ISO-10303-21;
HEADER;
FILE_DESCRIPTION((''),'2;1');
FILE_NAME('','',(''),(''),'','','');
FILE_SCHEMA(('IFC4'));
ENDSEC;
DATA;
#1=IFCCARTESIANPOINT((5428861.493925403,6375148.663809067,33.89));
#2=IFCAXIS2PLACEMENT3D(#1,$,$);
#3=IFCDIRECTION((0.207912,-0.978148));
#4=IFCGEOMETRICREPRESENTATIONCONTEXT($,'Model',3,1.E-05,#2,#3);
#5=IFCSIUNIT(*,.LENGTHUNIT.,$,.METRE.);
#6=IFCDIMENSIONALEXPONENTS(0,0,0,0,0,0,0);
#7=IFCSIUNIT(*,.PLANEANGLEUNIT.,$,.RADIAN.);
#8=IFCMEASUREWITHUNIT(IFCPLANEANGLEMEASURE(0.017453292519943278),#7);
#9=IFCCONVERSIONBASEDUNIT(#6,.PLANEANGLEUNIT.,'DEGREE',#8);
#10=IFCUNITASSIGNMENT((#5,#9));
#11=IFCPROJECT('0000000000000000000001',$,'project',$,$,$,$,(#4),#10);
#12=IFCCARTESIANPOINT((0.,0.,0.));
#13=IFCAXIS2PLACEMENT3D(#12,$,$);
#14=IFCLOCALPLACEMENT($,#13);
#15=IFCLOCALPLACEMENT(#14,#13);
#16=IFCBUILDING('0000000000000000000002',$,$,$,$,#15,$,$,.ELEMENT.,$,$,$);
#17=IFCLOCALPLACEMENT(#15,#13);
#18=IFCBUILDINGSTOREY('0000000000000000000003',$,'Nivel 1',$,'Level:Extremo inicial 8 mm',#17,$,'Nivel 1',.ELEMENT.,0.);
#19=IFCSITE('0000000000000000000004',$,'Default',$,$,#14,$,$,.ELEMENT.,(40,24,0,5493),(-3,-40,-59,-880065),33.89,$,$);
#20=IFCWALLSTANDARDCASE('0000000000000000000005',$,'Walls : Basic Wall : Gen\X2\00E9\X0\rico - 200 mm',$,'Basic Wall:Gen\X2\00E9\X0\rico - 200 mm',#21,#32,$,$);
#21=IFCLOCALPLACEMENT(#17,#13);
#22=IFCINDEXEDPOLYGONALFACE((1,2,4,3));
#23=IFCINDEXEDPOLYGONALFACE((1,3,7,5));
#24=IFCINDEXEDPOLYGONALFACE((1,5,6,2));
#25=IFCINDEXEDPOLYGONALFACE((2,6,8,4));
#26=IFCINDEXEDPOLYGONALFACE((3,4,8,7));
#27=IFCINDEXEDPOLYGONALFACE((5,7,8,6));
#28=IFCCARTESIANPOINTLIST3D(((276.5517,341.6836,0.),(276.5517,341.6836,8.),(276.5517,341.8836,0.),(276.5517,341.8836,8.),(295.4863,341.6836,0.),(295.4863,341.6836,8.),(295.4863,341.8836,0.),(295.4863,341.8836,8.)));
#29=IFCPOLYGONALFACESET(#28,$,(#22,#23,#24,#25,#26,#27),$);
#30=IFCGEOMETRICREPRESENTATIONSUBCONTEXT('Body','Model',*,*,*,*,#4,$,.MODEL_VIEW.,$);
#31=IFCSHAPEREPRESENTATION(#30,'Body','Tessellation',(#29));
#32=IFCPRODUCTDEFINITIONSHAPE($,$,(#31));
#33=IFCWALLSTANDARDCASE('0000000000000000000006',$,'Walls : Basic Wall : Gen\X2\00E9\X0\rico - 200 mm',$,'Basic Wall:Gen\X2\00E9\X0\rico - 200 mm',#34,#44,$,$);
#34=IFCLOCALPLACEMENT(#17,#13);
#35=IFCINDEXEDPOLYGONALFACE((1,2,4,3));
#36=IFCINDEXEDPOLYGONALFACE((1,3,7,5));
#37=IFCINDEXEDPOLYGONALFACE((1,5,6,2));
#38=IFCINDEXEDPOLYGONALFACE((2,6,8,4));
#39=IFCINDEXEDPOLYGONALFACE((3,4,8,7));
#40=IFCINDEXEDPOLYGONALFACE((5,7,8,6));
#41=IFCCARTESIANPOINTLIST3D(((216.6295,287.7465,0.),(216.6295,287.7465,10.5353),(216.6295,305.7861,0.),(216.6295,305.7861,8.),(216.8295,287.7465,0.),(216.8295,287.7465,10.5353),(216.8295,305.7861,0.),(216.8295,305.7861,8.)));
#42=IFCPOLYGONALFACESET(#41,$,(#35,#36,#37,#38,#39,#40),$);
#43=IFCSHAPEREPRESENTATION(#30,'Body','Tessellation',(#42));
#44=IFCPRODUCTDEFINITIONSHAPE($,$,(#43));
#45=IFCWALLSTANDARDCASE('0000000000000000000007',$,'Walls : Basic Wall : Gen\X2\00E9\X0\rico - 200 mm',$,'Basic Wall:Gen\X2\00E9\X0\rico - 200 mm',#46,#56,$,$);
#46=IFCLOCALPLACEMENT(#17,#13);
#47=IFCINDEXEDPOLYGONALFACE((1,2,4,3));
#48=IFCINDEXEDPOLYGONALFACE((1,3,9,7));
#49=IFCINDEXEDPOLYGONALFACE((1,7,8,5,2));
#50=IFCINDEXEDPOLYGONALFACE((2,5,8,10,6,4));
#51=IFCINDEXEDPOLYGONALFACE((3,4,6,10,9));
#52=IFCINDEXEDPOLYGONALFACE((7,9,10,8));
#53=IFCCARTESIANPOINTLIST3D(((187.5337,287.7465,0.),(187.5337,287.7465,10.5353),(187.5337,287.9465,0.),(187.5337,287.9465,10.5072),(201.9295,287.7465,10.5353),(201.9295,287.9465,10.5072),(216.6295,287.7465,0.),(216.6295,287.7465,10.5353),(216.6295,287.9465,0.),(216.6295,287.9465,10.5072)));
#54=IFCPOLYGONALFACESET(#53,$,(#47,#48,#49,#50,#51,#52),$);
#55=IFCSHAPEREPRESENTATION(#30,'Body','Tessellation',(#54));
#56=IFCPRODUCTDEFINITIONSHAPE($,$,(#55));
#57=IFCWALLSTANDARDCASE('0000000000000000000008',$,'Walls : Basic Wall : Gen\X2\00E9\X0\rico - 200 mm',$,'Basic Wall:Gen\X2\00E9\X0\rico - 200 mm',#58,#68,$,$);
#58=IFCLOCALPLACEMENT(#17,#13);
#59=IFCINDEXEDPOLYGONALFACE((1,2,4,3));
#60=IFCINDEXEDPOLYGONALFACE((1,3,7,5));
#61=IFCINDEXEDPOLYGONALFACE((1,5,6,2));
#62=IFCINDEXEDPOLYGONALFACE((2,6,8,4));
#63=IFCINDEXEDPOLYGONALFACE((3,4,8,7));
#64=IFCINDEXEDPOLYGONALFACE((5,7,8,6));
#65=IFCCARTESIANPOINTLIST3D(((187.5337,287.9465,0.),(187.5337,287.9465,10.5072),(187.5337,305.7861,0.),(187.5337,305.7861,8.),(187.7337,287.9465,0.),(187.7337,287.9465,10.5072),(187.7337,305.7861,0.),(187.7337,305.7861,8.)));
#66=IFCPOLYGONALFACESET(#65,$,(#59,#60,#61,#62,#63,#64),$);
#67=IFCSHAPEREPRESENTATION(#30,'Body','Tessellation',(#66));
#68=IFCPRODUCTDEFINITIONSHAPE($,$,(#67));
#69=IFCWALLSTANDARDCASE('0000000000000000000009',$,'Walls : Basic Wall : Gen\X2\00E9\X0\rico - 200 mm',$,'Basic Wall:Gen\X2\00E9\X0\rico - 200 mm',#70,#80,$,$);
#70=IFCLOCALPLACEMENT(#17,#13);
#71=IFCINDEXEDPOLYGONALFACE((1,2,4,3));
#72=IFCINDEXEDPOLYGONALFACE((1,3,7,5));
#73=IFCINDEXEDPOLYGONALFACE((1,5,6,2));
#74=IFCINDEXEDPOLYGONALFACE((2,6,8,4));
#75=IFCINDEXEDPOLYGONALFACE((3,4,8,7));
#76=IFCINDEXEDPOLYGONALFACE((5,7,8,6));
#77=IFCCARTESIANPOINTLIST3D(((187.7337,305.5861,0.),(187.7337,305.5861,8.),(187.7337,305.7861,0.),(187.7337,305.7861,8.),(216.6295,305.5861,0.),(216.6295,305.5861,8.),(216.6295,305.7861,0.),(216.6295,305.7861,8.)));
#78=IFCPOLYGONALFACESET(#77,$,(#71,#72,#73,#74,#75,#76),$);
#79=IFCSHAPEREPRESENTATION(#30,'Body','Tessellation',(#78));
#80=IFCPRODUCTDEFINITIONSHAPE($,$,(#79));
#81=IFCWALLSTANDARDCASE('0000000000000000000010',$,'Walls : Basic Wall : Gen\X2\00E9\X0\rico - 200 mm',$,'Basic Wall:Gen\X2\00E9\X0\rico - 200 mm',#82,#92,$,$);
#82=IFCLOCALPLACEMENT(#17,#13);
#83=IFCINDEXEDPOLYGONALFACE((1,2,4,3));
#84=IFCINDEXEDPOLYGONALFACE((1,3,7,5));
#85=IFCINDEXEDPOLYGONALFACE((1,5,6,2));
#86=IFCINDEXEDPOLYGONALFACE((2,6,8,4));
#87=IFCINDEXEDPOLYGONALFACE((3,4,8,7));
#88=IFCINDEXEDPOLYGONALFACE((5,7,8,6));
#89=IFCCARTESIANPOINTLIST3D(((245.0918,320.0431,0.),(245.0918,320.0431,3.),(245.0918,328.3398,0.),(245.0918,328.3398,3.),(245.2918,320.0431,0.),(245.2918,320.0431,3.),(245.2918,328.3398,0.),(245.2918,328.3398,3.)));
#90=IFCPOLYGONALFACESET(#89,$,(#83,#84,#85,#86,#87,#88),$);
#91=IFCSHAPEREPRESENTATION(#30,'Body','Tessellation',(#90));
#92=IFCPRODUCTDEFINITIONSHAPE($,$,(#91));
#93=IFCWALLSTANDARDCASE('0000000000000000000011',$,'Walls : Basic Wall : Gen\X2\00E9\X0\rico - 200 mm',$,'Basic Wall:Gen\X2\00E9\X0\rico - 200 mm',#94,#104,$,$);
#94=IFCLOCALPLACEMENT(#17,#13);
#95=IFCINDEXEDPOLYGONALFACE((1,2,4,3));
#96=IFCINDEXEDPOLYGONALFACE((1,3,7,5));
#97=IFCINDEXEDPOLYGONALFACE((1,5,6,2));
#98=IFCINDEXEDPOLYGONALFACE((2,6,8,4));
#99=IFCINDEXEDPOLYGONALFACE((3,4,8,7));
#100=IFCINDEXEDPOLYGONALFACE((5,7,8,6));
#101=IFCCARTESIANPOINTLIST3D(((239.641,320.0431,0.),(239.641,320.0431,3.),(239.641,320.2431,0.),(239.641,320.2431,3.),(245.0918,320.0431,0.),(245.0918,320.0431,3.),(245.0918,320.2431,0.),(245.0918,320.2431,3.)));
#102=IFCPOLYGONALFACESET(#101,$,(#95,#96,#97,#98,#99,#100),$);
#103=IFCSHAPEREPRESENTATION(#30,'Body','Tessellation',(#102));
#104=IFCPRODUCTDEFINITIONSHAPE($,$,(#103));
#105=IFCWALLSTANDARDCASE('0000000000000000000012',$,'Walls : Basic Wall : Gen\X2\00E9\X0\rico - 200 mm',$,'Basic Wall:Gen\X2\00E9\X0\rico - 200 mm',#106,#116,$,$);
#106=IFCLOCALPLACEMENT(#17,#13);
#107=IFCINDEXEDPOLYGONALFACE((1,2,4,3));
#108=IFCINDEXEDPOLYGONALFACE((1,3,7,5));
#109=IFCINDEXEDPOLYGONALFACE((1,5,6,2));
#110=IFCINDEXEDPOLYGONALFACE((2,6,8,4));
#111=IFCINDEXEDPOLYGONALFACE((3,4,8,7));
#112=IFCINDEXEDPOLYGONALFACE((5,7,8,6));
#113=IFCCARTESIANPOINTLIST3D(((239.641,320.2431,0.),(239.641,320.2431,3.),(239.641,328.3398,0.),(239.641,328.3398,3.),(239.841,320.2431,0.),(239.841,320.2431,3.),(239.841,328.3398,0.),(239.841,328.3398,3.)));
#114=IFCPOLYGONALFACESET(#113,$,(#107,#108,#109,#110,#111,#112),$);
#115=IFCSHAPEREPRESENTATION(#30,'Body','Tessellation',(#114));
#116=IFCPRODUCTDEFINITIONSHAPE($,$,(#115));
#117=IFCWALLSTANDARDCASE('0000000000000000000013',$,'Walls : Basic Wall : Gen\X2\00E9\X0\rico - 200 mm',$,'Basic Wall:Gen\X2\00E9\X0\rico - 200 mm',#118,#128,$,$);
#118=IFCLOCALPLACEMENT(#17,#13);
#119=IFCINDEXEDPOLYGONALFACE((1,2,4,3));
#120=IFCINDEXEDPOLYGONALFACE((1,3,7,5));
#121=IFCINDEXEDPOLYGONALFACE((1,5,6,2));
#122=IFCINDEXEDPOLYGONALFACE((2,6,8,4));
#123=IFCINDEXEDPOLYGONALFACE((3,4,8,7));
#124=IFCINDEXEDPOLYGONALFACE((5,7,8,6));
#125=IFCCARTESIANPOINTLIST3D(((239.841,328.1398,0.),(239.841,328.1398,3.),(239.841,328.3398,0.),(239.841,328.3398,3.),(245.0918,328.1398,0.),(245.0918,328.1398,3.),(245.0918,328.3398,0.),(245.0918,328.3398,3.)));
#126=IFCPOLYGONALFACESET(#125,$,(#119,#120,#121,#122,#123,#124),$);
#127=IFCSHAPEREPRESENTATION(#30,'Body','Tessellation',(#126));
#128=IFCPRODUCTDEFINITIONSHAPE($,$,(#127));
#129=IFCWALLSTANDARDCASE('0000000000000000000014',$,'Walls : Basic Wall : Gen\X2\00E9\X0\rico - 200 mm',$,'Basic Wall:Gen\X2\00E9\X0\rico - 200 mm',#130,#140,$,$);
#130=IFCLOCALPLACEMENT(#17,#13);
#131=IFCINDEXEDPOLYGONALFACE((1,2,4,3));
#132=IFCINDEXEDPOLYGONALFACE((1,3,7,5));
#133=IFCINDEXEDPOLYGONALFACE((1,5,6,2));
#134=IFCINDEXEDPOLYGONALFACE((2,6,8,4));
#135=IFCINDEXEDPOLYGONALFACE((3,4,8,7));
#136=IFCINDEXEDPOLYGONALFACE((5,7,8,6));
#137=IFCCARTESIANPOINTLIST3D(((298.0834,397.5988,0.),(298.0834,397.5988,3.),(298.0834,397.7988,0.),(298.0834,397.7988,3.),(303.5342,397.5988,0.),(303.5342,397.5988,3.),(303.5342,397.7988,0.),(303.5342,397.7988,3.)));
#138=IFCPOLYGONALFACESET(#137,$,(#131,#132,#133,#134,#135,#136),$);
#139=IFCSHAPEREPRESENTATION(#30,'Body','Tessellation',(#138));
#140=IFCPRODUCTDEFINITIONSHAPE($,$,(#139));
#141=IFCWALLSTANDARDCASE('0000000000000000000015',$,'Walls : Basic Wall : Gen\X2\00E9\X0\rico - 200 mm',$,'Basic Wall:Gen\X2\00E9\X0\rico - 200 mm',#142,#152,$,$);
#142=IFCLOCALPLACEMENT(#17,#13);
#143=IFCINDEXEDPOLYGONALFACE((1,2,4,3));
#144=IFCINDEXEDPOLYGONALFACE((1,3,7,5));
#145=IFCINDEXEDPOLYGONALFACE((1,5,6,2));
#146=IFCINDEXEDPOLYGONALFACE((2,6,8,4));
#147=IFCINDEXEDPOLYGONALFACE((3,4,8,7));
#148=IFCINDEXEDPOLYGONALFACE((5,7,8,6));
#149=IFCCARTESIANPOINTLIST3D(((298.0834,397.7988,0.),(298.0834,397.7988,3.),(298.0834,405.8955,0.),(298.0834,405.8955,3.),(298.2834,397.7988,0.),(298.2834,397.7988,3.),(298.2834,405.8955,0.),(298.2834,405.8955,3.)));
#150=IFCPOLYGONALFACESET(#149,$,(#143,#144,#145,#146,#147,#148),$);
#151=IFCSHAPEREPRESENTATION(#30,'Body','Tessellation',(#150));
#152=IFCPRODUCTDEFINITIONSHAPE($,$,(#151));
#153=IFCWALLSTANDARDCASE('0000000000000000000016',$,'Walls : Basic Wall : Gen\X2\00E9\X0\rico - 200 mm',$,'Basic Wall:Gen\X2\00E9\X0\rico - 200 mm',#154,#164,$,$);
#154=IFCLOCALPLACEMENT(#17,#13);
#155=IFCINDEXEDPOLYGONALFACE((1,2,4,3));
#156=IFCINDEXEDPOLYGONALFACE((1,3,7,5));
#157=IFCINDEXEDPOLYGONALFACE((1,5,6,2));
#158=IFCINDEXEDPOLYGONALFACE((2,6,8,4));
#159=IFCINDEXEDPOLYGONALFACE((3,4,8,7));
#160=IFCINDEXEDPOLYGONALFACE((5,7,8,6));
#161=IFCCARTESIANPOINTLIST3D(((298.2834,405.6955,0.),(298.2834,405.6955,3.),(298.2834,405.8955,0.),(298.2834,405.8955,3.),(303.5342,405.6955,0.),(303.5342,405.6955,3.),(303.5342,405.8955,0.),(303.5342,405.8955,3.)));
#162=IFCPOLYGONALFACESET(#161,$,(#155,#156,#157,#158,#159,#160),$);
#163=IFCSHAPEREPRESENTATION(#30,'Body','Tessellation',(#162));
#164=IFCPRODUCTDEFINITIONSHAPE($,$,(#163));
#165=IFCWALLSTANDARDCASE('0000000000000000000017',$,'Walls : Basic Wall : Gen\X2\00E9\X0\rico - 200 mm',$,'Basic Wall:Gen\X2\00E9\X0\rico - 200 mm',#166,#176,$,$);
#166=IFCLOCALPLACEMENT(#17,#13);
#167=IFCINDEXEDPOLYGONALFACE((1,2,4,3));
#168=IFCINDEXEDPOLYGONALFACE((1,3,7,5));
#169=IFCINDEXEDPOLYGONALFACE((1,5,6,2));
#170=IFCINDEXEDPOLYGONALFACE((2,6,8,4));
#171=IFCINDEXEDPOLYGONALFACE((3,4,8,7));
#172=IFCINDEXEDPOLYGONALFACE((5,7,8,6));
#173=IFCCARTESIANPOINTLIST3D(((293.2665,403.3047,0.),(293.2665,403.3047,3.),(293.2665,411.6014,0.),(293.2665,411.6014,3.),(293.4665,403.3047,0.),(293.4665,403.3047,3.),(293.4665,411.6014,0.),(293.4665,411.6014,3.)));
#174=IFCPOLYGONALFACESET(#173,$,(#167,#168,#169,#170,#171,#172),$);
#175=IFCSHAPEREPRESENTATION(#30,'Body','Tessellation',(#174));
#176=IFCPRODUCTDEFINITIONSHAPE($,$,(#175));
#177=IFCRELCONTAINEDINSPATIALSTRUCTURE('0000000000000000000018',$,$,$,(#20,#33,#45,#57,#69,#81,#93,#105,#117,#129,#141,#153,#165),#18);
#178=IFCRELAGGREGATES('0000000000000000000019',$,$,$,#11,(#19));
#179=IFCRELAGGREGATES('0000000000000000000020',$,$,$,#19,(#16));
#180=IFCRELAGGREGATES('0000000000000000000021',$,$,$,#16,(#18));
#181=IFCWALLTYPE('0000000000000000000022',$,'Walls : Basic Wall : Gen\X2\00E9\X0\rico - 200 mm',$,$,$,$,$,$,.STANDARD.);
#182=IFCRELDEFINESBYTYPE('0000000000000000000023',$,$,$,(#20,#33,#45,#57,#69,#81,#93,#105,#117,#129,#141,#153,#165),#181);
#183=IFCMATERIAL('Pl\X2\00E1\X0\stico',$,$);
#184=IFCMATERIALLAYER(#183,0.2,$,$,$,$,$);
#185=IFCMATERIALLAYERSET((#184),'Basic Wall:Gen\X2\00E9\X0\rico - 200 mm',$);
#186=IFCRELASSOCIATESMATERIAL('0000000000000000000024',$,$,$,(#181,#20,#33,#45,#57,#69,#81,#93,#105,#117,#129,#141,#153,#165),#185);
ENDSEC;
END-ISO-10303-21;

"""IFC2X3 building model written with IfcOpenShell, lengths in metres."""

from ifc_helpers import new_model, entity, si_unit, converted_unit, direction, frame, frame_2d, origin, place, context, subcontext, project, spatial, polyline, rectangle, extrude, clip, bounded_halfspace, material, layer, layer_set, layer_usage, type_object, element, save


model = new_model("IFC2X3")

# Units and contexts
model_context = context("Model", 3, precision=1e-05, world=frame((5428861.493925403, 6375148.663809067, 33.89)), true_north=direction((0.207912, -0.978148)))
body_context = subcontext(model_context, "Body", "Model", "MODEL_VIEW")
ifc_project = project(units=[si_unit("LENGTHUNIT", "METRE"), converted_unit("PLANEANGLEUNIT", "DEGREE", entity("IfcPlaneAngleMeasure", 0.017453292519943278), si_unit("PLANEANGLEUNIT", "RADIAN"), dimensions=[0, 0, 0, 0, 0, 0, 0])], contexts=[model_context])

# Site, building, storey
site_placement = place(None, origin())
site = spatial("IfcSite", under=ifc_project, at=site_placement, Name="Default", CompositionType="ELEMENT", RefLatitude=(40, 24, 0, 5493), RefLongitude=(-3, -40, -59, -880065), RefElevation=33.89)
building_placement = place(site_placement, origin())
building = spatial("IfcBuilding", under=site, at=building_placement, CompositionType="ELEMENT")
storey_placement = place(building_placement, origin())
storey = spatial("IfcBuildingStorey", under=building, at=storey_placement, Name="Nivel 1", ObjectType="Level:Extremo inicial 8 mm", LongName="Nivel 1", CompositionType="ELEMENT", Elevation=0.0)

# Walls
ifc_material_1 = material(Name="Plástico")
ifc_layer_1 = layer(ifc_material_1, 0.2)
ifc_layer_set_1 = layer_set([ifc_layer_1], Name="Basic Wall:Genérico - 200 mm")
wall_type = type_object("IfcWallType", Name="Walls : Basic Wall : Genérico - 200 mm", PredefinedType="STANDARD", material=ifc_layer_set_1)
ifc_layer_usage_1 = layer_usage(ifc_layer_set_1, "AXIS2", "NEGATIVE", 0.1)
wall_1_placement = place(storey_placement, frame((276.5517, 341.7836, 0.0)))
element("IfcWallStandardCase", 1, at=wall_1_placement, inside=storey, type_object=wall_type, material=ifc_layer_usage_1, Name="Walls : Basic Wall : Genérico - 200 mm", ObjectType="Basic Wall:Genérico - 200 mm", context=body_context, shape_type="SweptSolid", body=[
    extrude(rectangle(XDim=18.9346, YDim=0.2, at=frame_2d((9.4673, 0.0), x_axis=(-1.0, 0.0))), origin(), (0.0, 0.0, 1.0), 8.0),
])
ifc_layer_usage_2 = layer_usage(ifc_layer_set_1, "AXIS2", "NEGATIVE", 0.1)
wall_2_placement = place(storey_placement, frame((216.7295, 305.7861, 0.0), z_axis=(0.0, 0.0, 1.0), x_axis=(0.0, -1.0, 0.0)))
element("IfcWallStandardCase", 2, at=wall_2_placement, inside=storey, type_object=wall_type, material=ifc_layer_usage_2, Name="Walls : Basic Wall : Genérico - 200 mm", ObjectType="Basic Wall:Genérico - 200 mm", context=body_context, shape_type="Clipping", body=[
    clip(extrude(rectangle(XDim=18.0396, YDim=0.2, at=frame_2d((9.0198, 0.0), x_axis=(-1.0, 0.0))), origin(), (0.0, 0.0, 1.0), 10.5353), bounded_halfspace(frame((0.0, -0.1, 8.0), z_axis=(-0.139173, 0.0, 0.990268), x_axis=(0.0, -1.0, 0.0)), False, frame((0.0, -0.1, 8.0)), polyline([(0.0, 0.0), (17.8396, 0.0), (18.0396, 0.0), (18.0396, 0.2), (0.0, 0.2), (0.0, 0.0)]))),
])
ifc_layer_usage_3 = layer_usage(ifc_layer_set_1, "AXIS2", "NEGATIVE", 0.1)
wall_3_placement = place(storey_placement, frame((216.6295, 287.8465, 0.0), z_axis=(0.0, 0.0, 1.0), x_axis=(-1.0, 0.0, 0.0)))
element("IfcWallStandardCase", 3, at=wall_3_placement, inside=storey, type_object=wall_type, material=ifc_layer_usage_3, Name="Walls : Basic Wall : Genérico - 200 mm", ObjectType="Basic Wall:Genérico - 200 mm", context=body_context, shape_type="Clipping", body=[
    clip(clip(extrude(rectangle(XDim=29.0959, YDim=0.2, at=frame_2d((14.5479, 0.0), x_axis=(-1.0, 0.0))), origin(), (0.0, 0.0, 1.0), 10.5353), bounded_halfspace(frame((14.7, -0.1, 10.5072), z_axis=(0.0, -0.139173, 0.990268), x_axis=(1.0, 0.0, 0.0)), False, frame((14.7, -0.1, 10.5072)), polyline([(0.0, 0.0), (14.1959, 0.0), (14.3959, 0.0), (14.3959, 0.2), (0.0, 0.2), (0.0, 0.0)]))), bounded_halfspace(frame((0.0, -0.1, 10.5072), z_axis=(0.0, -0.139173, 0.990268), x_axis=(1.0, 0.0, 0.0)), False, frame((0.0, -0.1, 10.5072)), polyline([(0.0, 0.0), (14.7, 0.0), (14.7, 0.2), (0.0, 0.2), (0.0, 0.0)]))),
])
ifc_layer_usage_4 = layer_usage(ifc_layer_set_1, "AXIS2", "NEGATIVE", 0.1)
wall_4_placement = place(storey_placement, frame((187.6337, 287.9465, 0.0), z_axis=(0.0, 0.0, 1.0), x_axis=(0.0, 1.0, 0.0)))
element("IfcWallStandardCase", 4, at=wall_4_placement, inside=storey, type_object=wall_type, material=ifc_layer_usage_4, Name="Walls : Basic Wall : Genérico - 200 mm", ObjectType="Basic Wall:Genérico - 200 mm", context=body_context, shape_type="Clipping", body=[
    clip(extrude(rectangle(XDim=17.8396, YDim=0.2, at=frame_2d((8.9198, 0.0), x_axis=(-1.0, 0.0))), origin(), (0.0, 0.0, 1.0), 10.5072), bounded_halfspace(frame((0.0, -0.1, 10.5072), z_axis=(0.139173, 0.0, 0.990268), x_axis=(0.0, 1.0, 0.0)), False, frame((0.0, -0.1, 10.5072)), polyline([(0.0, 0.0), (17.8396, 0.0), (17.8396, 0.2), (0.0, 0.2), (0.0, 0.0)]))),
])
ifc_layer_usage_5 = layer_usage(ifc_layer_set_1, "AXIS2", "NEGATIVE", 0.1)
wall_5_placement = place(storey_placement, frame((187.7337, 305.6861, 0.0)))
element("IfcWallStandardCase", 5, at=wall_5_placement, inside=storey, type_object=wall_type, material=ifc_layer_usage_5, Name="Walls : Basic Wall : Genérico - 200 mm", ObjectType="Basic Wall:Genérico - 200 mm", context=body_context, shape_type="SweptSolid", body=[
    extrude(rectangle(XDim=28.8959, YDim=0.2, at=frame_2d((14.4479, 0.0), x_axis=(-1.0, 0.0))), origin(), (0.0, 0.0, 1.0), 8.0),
])
ifc_layer_usage_6 = layer_usage(ifc_layer_set_1, "AXIS2", "NEGATIVE", 0.1)
wall_6_placement = place(storey_placement, frame((245.1918, 328.3398, 0.0), z_axis=(0.0, 0.0, 1.0), x_axis=(0.0, -1.0, 0.0)))
element("IfcWallStandardCase", 6, at=wall_6_placement, inside=storey, type_object=wall_type, material=ifc_layer_usage_6, Name="Walls : Basic Wall : Genérico - 200 mm", ObjectType="Basic Wall:Genérico - 200 mm", context=body_context, shape_type="SweptSolid", body=[
    extrude(rectangle(XDim=8.2967, YDim=0.2, at=frame_2d((4.1484, 0.0), x_axis=(-1.0, 0.0))), origin(), (0.0, 0.0, 1.0), 3.0),
])
ifc_layer_usage_7 = layer_usage(ifc_layer_set_1, "AXIS2", "NEGATIVE", 0.1)
wall_7_placement = place(storey_placement, frame((245.0918, 320.1431, 0.0), z_axis=(0.0, 0.0, 1.0), x_axis=(-1.0, 0.0, 0.0)))
element("IfcWallStandardCase", 7, at=wall_7_placement, inside=storey, type_object=wall_type, material=ifc_layer_usage_7, Name="Walls : Basic Wall : Genérico - 200 mm", ObjectType="Basic Wall:Genérico - 200 mm", context=body_context, shape_type="SweptSolid", body=[
    extrude(rectangle(XDim=5.4508, YDim=0.2, at=frame_2d((2.7254, 0.0), x_axis=(-1.0, 0.0))), origin(), (0.0, 0.0, 1.0), 3.0),
])
ifc_layer_usage_8 = layer_usage(ifc_layer_set_1, "AXIS2", "NEGATIVE", 0.1)
wall_8_placement = place(storey_placement, frame((239.741, 320.2431, 0.0), z_axis=(0.0, 0.0, 1.0), x_axis=(0.0, 1.0, 0.0)))
element("IfcWallStandardCase", 8, at=wall_8_placement, inside=storey, type_object=wall_type, material=ifc_layer_usage_8, Name="Walls : Basic Wall : Genérico - 200 mm", ObjectType="Basic Wall:Genérico - 200 mm", context=body_context, shape_type="SweptSolid", body=[
    extrude(rectangle(XDim=8.0967, YDim=0.2, at=frame_2d((4.0484, 0.0), x_axis=(-1.0, 0.0))), origin(), (0.0, 0.0, 1.0), 3.0),
])
ifc_layer_usage_9 = layer_usage(ifc_layer_set_1, "AXIS2", "NEGATIVE", 0.1)
wall_9_placement = place(storey_placement, frame((239.841, 328.2398, 0.0)))
element("IfcWallStandardCase", 9, at=wall_9_placement, inside=storey, type_object=wall_type, material=ifc_layer_usage_9, Name="Walls : Basic Wall : Genérico - 200 mm", ObjectType="Basic Wall:Genérico - 200 mm", context=body_context, shape_type="SweptSolid", body=[
    extrude(rectangle(XDim=5.2508, YDim=0.2, at=frame_2d((2.6254, 0.0), x_axis=(-1.0, 0.0))), origin(), (0.0, 0.0, 1.0), 3.0),
])
ifc_layer_usage_10 = layer_usage(ifc_layer_set_1, "AXIS2", "NEGATIVE", 0.1)
wall_10_placement = place(storey_placement, frame((303.5342, 397.6988, 0.0), z_axis=(0.0, 0.0, 1.0), x_axis=(-1.0, 0.0, 0.0)))
element("IfcWallStandardCase", 10, at=wall_10_placement, inside=storey, type_object=wall_type, material=ifc_layer_usage_10, Name="Walls : Basic Wall : Genérico - 200 mm", ObjectType="Basic Wall:Genérico - 200 mm", context=body_context, shape_type="SweptSolid", body=[
    extrude(rectangle(XDim=5.4508, YDim=0.2, at=frame_2d((2.7254, 0.0), x_axis=(-1.0, 0.0))), origin(), (0.0, 0.0, 1.0), 3.0),
])
ifc_layer_usage_11 = layer_usage(ifc_layer_set_1, "AXIS2", "NEGATIVE", 0.1)
wall_11_placement = place(storey_placement, frame((298.1834, 397.7988, 0.0), z_axis=(0.0, 0.0, 1.0), x_axis=(0.0, 1.0, 0.0)))
element("IfcWallStandardCase", 11, at=wall_11_placement, inside=storey, type_object=wall_type, material=ifc_layer_usage_11, Name="Walls : Basic Wall : Genérico - 200 mm", ObjectType="Basic Wall:Genérico - 200 mm", context=body_context, shape_type="SweptSolid", body=[
    extrude(rectangle(XDim=8.0967, YDim=0.2, at=frame_2d((4.0484, 0.0), x_axis=(-1.0, 0.0))), origin(), (0.0, 0.0, 1.0), 3.0),
])
ifc_layer_usage_12 = layer_usage(ifc_layer_set_1, "AXIS2", "NEGATIVE", 0.1)
wall_12_placement = place(storey_placement, frame((298.2834, 405.7955, 0.0)))
element("IfcWallStandardCase", 12, at=wall_12_placement, inside=storey, type_object=wall_type, material=ifc_layer_usage_12, Name="Walls : Basic Wall : Genérico - 200 mm", ObjectType="Basic Wall:Genérico - 200 mm", context=body_context, shape_type="SweptSolid", body=[
    extrude(rectangle(XDim=5.2508, YDim=0.2, at=frame_2d((2.6254, 0.0), x_axis=(-1.0, 0.0))), origin(), (0.0, 0.0, 1.0), 3.0),
])
ifc_layer_usage_13 = layer_usage(ifc_layer_set_1, "AXIS2", "NEGATIVE", 0.1)
wall_13_placement = place(storey_placement, frame((293.3665, 411.6014, 0.0), z_axis=(0.0, 0.0, 1.0), x_axis=(0.0, -1.0, 0.0)))
element("IfcWallStandardCase", 13, at=wall_13_placement, inside=storey, type_object=wall_type, material=ifc_layer_usage_13, Name="Walls : Basic Wall : Genérico - 200 mm", ObjectType="Basic Wall:Genérico - 200 mm", context=body_context, shape_type="SweptSolid", body=[
    extrude(rectangle(XDim=8.2967, YDim=0.2, at=frame_2d((4.1484, 0.0), x_axis=(-1.0, 0.0))), origin(), (0.0, 0.0, 1.0), 3.0),
])

save(model, "model.ifc")
